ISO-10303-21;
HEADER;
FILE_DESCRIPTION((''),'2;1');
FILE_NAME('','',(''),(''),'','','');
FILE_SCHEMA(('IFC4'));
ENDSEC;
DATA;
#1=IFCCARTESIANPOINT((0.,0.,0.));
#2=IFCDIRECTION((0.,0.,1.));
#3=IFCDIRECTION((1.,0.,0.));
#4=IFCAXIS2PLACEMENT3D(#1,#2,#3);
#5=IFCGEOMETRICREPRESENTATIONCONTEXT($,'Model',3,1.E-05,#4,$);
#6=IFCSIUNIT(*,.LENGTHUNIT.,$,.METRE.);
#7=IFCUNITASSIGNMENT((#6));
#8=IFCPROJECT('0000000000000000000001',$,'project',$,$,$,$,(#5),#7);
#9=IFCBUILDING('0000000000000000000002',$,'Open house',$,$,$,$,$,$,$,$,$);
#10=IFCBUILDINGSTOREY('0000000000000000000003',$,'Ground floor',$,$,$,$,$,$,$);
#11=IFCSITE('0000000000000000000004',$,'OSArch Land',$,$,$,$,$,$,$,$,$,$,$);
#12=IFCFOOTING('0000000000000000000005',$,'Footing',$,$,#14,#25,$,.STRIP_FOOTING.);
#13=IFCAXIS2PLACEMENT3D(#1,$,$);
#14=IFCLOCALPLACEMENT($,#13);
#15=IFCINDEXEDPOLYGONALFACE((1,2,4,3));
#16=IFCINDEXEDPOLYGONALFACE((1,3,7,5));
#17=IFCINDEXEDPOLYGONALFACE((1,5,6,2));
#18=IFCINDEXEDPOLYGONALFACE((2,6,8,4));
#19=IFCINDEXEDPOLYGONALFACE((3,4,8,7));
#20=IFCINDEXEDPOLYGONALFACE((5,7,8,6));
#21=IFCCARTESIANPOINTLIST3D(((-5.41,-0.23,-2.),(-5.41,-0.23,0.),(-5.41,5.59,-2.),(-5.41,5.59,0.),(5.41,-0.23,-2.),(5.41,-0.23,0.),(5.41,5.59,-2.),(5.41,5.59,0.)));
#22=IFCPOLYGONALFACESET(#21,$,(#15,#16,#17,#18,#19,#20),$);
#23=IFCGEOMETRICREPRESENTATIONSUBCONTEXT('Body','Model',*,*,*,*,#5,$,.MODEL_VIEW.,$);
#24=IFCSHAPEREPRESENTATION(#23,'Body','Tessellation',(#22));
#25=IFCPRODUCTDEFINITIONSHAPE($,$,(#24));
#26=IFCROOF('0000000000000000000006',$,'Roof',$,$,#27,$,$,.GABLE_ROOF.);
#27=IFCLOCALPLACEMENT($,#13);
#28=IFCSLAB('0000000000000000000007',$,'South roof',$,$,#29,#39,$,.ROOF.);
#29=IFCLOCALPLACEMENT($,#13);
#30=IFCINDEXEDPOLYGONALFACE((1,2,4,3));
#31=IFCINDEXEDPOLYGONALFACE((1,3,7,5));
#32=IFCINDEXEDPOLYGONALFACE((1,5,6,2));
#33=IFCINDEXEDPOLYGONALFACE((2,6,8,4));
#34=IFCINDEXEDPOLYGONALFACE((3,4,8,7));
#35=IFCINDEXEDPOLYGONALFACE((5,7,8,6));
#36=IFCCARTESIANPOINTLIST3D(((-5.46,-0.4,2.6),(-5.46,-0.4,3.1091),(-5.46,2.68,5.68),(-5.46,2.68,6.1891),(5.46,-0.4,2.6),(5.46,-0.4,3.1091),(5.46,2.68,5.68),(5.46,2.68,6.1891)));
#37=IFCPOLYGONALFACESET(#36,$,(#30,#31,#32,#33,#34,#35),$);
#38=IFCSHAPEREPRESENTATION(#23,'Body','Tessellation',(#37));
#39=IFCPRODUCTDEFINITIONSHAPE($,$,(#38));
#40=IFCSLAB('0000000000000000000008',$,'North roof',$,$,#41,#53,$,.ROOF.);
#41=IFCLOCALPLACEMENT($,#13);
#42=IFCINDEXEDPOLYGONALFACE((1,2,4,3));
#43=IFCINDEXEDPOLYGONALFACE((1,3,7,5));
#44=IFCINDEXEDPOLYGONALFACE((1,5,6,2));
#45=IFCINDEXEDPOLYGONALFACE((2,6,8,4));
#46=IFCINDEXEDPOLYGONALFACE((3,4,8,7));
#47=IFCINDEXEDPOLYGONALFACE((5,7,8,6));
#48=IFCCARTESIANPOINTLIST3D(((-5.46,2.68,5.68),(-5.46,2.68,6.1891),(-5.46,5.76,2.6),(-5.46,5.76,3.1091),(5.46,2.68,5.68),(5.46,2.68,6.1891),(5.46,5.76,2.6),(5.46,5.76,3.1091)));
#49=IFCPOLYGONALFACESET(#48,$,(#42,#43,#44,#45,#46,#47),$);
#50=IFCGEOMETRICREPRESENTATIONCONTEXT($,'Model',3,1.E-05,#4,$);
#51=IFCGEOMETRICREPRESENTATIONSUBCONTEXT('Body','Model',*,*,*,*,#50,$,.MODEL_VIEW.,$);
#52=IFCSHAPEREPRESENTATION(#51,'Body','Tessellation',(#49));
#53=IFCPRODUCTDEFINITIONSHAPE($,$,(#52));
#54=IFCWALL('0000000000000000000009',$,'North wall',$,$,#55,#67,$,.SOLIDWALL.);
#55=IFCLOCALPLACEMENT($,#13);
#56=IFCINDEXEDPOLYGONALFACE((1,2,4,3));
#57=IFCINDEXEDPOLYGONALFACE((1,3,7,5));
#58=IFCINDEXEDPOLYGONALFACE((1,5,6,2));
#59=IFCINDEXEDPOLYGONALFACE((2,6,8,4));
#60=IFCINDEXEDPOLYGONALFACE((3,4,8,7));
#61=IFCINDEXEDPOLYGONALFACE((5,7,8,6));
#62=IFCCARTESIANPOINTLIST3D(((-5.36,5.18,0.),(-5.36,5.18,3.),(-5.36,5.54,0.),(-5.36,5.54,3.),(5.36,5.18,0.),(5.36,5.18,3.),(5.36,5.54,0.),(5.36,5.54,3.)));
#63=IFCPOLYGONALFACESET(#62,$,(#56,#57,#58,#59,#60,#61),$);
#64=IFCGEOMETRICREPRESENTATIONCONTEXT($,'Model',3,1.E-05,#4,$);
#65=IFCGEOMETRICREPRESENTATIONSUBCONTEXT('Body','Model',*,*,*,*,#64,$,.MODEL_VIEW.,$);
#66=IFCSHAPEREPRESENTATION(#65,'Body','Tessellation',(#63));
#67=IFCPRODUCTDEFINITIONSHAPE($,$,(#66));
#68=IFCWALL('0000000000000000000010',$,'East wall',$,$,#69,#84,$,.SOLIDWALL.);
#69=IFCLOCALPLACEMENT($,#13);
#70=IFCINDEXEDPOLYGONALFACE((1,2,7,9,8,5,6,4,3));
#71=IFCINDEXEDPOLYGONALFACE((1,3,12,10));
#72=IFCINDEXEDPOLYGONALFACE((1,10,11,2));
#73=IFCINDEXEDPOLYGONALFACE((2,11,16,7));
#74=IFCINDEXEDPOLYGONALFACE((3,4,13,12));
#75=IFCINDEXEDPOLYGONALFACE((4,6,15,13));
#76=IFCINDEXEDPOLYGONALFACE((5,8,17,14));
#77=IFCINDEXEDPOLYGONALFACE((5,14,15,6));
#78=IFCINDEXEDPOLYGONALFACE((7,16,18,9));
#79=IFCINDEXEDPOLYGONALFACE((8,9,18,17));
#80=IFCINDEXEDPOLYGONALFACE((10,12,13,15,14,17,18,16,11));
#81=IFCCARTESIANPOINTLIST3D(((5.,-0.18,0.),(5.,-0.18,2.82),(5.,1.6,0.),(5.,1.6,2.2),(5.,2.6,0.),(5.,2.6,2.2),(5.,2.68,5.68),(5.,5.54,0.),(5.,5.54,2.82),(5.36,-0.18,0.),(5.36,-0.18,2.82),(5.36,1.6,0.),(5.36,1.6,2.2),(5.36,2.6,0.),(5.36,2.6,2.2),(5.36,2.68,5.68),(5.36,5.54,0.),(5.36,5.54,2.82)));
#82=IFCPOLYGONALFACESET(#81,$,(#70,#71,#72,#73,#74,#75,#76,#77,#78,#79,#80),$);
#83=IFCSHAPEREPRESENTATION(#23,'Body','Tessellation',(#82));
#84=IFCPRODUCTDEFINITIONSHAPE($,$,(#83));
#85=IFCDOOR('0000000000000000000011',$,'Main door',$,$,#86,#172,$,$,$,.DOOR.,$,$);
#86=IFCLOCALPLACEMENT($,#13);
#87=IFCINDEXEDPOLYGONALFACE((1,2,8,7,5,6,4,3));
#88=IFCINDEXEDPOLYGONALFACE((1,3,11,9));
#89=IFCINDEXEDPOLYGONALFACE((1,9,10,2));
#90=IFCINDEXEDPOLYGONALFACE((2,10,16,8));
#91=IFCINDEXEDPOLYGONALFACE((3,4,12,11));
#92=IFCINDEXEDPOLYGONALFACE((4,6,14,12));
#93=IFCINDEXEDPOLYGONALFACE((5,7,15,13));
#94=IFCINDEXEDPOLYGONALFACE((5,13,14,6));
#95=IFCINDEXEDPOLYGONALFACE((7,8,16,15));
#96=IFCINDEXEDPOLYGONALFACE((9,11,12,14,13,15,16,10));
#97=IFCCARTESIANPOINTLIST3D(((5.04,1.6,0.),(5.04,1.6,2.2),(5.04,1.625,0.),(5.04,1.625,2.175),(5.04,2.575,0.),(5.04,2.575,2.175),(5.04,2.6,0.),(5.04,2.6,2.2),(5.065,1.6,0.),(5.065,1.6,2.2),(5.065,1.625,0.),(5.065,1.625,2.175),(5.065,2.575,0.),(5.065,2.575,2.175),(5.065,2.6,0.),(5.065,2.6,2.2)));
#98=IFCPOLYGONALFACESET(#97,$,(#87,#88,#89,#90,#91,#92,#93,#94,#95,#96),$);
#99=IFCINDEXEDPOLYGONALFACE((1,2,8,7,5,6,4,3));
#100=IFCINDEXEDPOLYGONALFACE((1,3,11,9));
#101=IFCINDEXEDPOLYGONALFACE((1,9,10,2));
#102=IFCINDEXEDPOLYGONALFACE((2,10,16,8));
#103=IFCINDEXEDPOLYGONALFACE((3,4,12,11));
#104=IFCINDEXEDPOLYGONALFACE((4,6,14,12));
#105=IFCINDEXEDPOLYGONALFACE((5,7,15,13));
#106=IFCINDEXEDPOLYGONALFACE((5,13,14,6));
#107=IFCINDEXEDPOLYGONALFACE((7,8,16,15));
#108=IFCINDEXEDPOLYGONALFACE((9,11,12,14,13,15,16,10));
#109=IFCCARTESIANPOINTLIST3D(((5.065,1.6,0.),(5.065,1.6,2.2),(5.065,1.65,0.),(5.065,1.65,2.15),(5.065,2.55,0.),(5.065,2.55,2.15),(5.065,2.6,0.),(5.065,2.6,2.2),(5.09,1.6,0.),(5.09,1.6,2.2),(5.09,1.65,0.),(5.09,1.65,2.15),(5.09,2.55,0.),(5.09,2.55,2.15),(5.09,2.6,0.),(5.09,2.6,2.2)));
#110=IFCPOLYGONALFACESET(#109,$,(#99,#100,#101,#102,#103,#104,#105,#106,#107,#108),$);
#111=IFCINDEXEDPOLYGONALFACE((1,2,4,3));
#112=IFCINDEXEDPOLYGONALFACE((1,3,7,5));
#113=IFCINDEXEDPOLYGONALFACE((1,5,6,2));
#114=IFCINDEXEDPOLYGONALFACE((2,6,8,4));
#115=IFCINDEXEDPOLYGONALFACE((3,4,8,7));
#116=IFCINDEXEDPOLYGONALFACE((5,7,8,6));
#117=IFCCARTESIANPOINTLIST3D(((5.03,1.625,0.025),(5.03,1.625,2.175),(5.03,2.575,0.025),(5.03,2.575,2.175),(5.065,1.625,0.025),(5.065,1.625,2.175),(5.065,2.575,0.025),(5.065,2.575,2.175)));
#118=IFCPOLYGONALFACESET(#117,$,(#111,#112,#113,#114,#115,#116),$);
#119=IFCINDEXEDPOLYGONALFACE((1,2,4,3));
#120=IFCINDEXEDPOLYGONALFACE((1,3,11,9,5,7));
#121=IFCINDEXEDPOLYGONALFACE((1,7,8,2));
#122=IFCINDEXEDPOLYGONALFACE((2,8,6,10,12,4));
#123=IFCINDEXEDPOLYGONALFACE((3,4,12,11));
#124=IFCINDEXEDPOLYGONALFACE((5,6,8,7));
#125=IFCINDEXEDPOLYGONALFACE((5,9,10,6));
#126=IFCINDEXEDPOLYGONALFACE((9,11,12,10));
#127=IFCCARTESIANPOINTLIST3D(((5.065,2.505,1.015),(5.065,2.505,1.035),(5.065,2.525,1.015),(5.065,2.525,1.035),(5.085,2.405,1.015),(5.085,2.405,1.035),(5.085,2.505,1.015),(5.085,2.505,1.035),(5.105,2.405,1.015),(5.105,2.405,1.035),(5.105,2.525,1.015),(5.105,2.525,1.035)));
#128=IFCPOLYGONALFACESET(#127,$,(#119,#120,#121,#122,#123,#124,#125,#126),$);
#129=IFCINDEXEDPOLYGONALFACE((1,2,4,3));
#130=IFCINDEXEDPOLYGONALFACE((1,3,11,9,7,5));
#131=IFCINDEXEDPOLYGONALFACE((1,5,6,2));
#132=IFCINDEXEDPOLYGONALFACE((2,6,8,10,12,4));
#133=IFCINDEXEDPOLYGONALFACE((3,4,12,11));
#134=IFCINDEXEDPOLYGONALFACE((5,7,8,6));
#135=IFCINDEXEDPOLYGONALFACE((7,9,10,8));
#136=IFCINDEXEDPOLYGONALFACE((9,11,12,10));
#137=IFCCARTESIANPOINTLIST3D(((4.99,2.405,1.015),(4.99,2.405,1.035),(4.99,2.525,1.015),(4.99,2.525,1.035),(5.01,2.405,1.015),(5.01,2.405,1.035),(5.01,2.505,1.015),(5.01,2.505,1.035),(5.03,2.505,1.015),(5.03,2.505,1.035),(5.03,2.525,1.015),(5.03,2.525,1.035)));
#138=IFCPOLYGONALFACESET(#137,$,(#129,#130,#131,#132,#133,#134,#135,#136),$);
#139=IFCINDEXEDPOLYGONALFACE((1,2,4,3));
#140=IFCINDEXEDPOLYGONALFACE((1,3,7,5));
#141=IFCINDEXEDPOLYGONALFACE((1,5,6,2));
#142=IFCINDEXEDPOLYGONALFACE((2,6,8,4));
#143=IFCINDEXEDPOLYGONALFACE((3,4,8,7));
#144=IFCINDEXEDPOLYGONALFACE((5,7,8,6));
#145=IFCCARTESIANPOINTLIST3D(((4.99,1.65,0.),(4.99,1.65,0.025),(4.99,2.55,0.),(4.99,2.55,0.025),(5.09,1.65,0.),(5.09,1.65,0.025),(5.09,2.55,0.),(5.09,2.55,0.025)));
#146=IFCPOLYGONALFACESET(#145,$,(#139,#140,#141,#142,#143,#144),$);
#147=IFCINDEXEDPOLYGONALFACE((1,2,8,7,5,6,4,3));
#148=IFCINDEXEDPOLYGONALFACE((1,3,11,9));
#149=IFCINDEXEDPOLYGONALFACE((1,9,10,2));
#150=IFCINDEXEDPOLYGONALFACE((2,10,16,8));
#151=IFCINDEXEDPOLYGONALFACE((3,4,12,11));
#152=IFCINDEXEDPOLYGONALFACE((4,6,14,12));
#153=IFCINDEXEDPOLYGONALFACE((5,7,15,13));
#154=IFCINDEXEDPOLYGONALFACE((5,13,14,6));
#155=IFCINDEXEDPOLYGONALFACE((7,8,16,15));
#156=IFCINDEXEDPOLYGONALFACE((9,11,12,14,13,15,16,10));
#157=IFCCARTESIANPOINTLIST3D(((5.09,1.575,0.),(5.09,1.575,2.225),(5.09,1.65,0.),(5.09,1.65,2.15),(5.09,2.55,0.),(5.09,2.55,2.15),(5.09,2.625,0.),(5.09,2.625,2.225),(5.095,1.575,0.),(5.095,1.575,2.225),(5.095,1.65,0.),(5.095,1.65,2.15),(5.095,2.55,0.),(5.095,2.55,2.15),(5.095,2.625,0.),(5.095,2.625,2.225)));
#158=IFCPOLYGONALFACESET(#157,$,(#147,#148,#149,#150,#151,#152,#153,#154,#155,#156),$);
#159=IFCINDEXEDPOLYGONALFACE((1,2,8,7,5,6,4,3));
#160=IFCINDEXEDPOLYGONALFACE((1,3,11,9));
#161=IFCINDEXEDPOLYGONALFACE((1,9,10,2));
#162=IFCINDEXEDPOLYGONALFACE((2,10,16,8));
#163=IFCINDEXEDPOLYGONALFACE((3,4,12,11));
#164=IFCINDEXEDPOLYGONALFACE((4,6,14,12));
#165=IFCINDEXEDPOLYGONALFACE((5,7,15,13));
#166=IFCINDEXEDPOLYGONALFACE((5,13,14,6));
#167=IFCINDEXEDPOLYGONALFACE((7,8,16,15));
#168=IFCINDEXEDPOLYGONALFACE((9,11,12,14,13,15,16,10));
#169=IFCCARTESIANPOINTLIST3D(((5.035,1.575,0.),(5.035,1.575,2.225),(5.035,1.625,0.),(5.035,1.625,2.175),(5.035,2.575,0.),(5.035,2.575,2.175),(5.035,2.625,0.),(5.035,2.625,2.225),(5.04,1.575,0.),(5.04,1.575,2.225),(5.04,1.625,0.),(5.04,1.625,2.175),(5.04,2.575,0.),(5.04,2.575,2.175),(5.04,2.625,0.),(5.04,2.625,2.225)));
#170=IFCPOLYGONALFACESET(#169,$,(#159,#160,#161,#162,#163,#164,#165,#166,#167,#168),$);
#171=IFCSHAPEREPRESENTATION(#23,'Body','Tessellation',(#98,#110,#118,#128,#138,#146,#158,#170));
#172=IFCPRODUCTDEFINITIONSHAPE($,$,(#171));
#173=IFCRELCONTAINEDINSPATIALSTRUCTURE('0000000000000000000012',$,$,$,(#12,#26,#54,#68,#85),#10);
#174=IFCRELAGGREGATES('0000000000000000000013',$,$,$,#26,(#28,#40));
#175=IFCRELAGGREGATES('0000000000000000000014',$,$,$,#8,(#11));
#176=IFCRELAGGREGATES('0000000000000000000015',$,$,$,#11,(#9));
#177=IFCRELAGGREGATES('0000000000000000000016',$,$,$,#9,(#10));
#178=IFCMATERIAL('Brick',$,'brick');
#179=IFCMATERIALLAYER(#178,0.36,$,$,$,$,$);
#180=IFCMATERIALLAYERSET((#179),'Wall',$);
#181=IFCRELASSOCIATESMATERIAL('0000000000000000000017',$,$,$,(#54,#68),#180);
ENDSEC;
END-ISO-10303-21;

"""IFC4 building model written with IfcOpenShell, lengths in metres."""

from ifc_helpers import new_model, si_unit, frame, origin_with_axes, place, context, subcontext, project, spatial, line, indexed_curve, outline, extrude, clip, halfspace, material, layer, layer_set, element, fill, aggregate, save


model = new_model("IFC4")

# Units and contexts
model_context_1 = context("Model", 3, precision=1e-05, world=origin_with_axes())
model_context_2 = context("Model", 3, precision=1e-05, world=origin_with_axes())
model_context_3 = context("Model", 3, precision=1e-05, world=origin_with_axes())
body_context_1 = subcontext(model_context_1, "Body", "Model", "MODEL_VIEW")
body_context_2 = subcontext(model_context_2, "Body", "Model", "MODEL_VIEW")
body_context_3 = subcontext(model_context_3, "Body", "Model", "MODEL_VIEW")
ifc_project = project(units=[si_unit("LENGTHUNIT", "METRE")], contexts=[model_context_1])

# Site, building, storey
site = spatial("IfcSite", under=ifc_project, Name="OSArch Land")
building = spatial("IfcBuilding", under=site, Name="Open house")
storey = spatial("IfcBuildingStorey", under=building, Name="Ground floor")

# Footing
footing_placement = place(None, frame((-5.41, -0.23, -2.0), z_axis=(0.0, 0.0, 1.0), x_axis=(1.0, 0.0, 0.0)))
element("IfcFooting", 1, at=footing_placement, inside=storey, Name="Footing", PredefinedType="STRIP_FOOTING", context=body_context_1, shape_type="SweptSolid", body=[
    extrude(outline(indexed_curve([(0.0, 0.0), (0.0, 5.82), (10.82, 5.82), (10.82, 0.0), (0.0, 0.0)], self_intersect=False)), origin_with_axes(), (0.0, 0.0, 1.0), 2.0),
])

# Roof, slabs
roof = element("IfcRoof", 2, inside=storey, Name="Roof", PredefinedType="GABLE_ROOF")
slab_1_placement = place(None, frame((5.46, -0.4, 2.6), z_axis=(0.0, 1.0, 0.0), x_axis=(-1.0, 0.0, 0.0)))
slab_1 = element("IfcSlab", 3, at=slab_1_placement, Name="South roof", PredefinedType="ROOF", context=body_context_1, shape_type="SweptSolid", body=[
    extrude(outline(indexed_curve([(0.0, 0.0), (0.0, 0.5091), (10.92, 0.5091), (10.92, 0.0), (0.0, 0.0)], self_intersect=False)), origin_with_axes(), (0.0, 0.707107, 0.707107), 4.3558),
])
slab_2_placement = place(None, frame((-5.46, 2.68, 6.1891), z_axis=(0.0, 1.0, 0.0), x_axis=(1.0, 0.0, 0.0)))
slab_2 = element("IfcSlab", 4, at=slab_2_placement, Name="North roof", PredefinedType="ROOF", context=body_context_2, shape_type="SweptSolid", body=[
    extrude(outline(indexed_curve([(0.0, 0.0), (0.0, 0.5091), (10.92, 0.5091), (10.92, 0.0), (0.0, 0.0)], self_intersect=False)), origin_with_axes(), (0.0, 0.707107, 0.707107), 4.3558),
])
aggregate(roof, [slab_1, slab_2])

# Shared definitions
ifc_material = material(Name="Brick", Category="brick")
ifc_layer = layer(ifc_material, 0.36)
ifc_layer_set = layer_set([ifc_layer], Name="Wall")

# Wall
wall_1_placement = place(None, frame((-5.36, 5.18, 0.0), z_axis=(0.0, 0.0, 1.0), x_axis=(1.0, 0.0, 0.0)))
element("IfcWall", 5, at=wall_1_placement, inside=storey, material=ifc_layer_set, Name="North wall", PredefinedType="SOLIDWALL", context=body_context_3, shape_type="SweptSolid", body=[
    extrude(outline(indexed_curve([(0.0, 0.0), (0.0, 0.36), (10.72, 0.36), (10.72, 0.0), (0.0, 0.0)], self_intersect=False)), origin_with_axes(), (0.0, 0.0, 1.0), 3.0),
])

# Wall, opening, door
wall_2_placement = place(None, frame((5.0, -0.18, 0.0), z_axis=(0.0, 0.0, 1.0), x_axis=(1.0, 0.0, 0.0)))
wall_2 = element("IfcWall", 6, at=wall_2_placement, inside=storey, material=ifc_layer_set, Name="East wall", PredefinedType="SOLIDWALL", context=body_context_1, shape_type="Clipping", body=[
    clip(clip(extrude(outline(indexed_curve([(0.0, 0.0), (0.0, 5.72), (0.36, 5.72), (0.36, 0.0), (0.0, 0.0)], self_intersect=False)), origin_with_axes(), (0.0, 0.0, 1.0), 6.08), halfspace(frame((0.0, 5.54, 3.0), z_axis=(0.0, 0.707107, 0.707107), x_axis=(1.0, 0.0, 0.0)), False)), halfspace(frame((0.0, 0.18, 3.0), z_axis=(0.0, -0.707107, 0.707107), x_axis=(1.0, 0.0, 0.0)), False)),
])
opening_1_placement = place(wall_2_placement, frame((-0.5, 1.78, 0.0), z_axis=(0.0, 0.0, 1.0), x_axis=(1.0, 0.0, 0.0)))
opening_1 = element("IfcOpeningElement", 7, at=opening_1_placement, cuts=wall_2, context=body_context_1, shape_type="SweptSolid", body=[
    extrude(outline(indexed_curve([(0.0, 0.0), (0.0, 1.0), (1.0, 1.0), (1.0, 0.0), (0.0, 0.0)], self_intersect=False)), origin_with_axes(), (0.0, 0.0, 1.0), 2.2),
])
door_placement = place(None, frame((5.09, 1.6, 0.0), z_axis=(0.0, 0.0, 1.0), x_axis=(0.0, 1.0, 0.0)))
door = element("IfcDoor", 8, at=door_placement, inside=storey, Name="Main door", PredefinedType="DOOR", context=body_context_1, shape_type="SweptSolid", body=[
    extrude(outline(indexed_curve([(0.0, 0.0), (0.0, 2.2), (1.0, 2.2), (1.0, 0.0), (0.975, 0.0), (0.975, 2.175), (0.025, 2.175), (0.025, 0.0)], segments=[line(1, 2), line(2, 3), line(3, 4), line(4, 5), line(5, 6), line(6, 7), line(7, 8), line(8, 1)])), frame((0.0, 0.025, 0.0), z_axis=(0.0, -1.0, 0.0), x_axis=(1.0, 0.0, 0.0)), (0.0, 0.0, -1.0), 0.025),
    extrude(outline(indexed_curve([(0.0, 0.0), (0.0, 2.2), (1.0, 2.2), (1.0, 0.0), (0.95, 0.0), (0.95, 2.15), (0.05, 2.15), (0.05, 0.0)], segments=[line(1, 2), line(2, 3), line(3, 4), line(4, 5), line(5, 6), line(6, 7), line(7, 8), line(8, 1)])), frame((0.0, 0.0, 0.0), z_axis=(0.0, -1.0, 0.0), x_axis=(1.0, 0.0, 0.0)), (0.0, 0.0, -1.0), 0.025),
    extrude(outline(indexed_curve([(0.0, 0.0), (0.95, 0.0), (0.95, 0.035), (0.0, 0.035)], segments=[line(1, 2), line(2, 3), line(3, 4), line(4, 1)])), frame((0.025, 0.025, 0.025), z_axis=(0.0, 0.0, 1.0), x_axis=(1.0, 0.0, 0.0)), (0.0, 0.0, 1.0), 2.15),
    extrude(outline(indexed_curve([(0.0, 0.0), (0.0, -0.04), (-0.12, -0.04), (-0.12, -0.02), (-0.02, -0.02), (-0.02, 0.0)], segments=[line(1, 2), line(2, 3), line(3, 4), line(4, 5), line(5, 6), line(6, 1)])), frame((0.925, 0.025, 1.015), z_axis=(0.0, 0.0, 1.0), x_axis=(1.0, 0.0, 0.0)), (0.0, 0.0, 1.0), 0.02),
    extrude(outline(indexed_curve([(0.0, 0.0), (0.0, 0.04), (-0.12, 0.04), (-0.12, 0.02), (-0.02, 0.02), (-0.02, 0.0)], segments=[line(1, 2), line(2, 3), line(3, 4), line(4, 5), line(5, 6), line(6, 1)])), frame((0.925, 0.06, 1.015), z_axis=(0.0, 0.0, 1.0), x_axis=(1.0, 0.0, 0.0)), (0.0, 0.0, 1.0), 0.02),
    extrude(outline(indexed_curve([(0.0, 0.0), (0.9, 0.0), (0.9, 0.1), (0.0, 0.1)], segments=[line(1, 2), line(2, 3), line(3, 4), line(4, 1)])), frame((0.05, 0.0, 0.0), z_axis=(0.0, 0.0, 1.0), x_axis=(1.0, 0.0, 0.0)), (0.0, 0.0, 1.0), 0.025),
    extrude(outline(indexed_curve([(0.0, 0.0), (0.0, 2.225), (1.05, 2.225), (1.05, 0.0), (0.975, 0.0), (0.975, 2.15), (0.075, 2.15), (0.075, 0.0)], segments=[line(1, 2), line(2, 3), line(3, 4), line(4, 5), line(5, 6), line(6, 7), line(7, 8), line(8, 1)])), frame((-0.025, -0.005, 0.0), z_axis=(0.0, -1.0, 0.0), x_axis=(1.0, 0.0, 0.0)), (0.0, 0.0, -1.0), 0.005),
    extrude(outline(indexed_curve([(0.0, 0.0), (0.0, 2.225), (1.05, 2.225), (1.05, 0.0), (1.0, 0.0), (1.0, 2.175), (0.05, 2.175), (0.05, 0.0)], segments=[line(1, 2), line(2, 3), line(3, 4), line(4, 5), line(5, 6), line(6, 7), line(7, 8), line(8, 1)])), frame((-0.025, 0.05, 0.0), z_axis=(0.0, -1.0, 0.0), x_axis=(1.0, 0.0, 0.0)), (0.0, 0.0, -1.0), 0.005),
])
fill(opening_1, door)

save(model, "model.ifc")
